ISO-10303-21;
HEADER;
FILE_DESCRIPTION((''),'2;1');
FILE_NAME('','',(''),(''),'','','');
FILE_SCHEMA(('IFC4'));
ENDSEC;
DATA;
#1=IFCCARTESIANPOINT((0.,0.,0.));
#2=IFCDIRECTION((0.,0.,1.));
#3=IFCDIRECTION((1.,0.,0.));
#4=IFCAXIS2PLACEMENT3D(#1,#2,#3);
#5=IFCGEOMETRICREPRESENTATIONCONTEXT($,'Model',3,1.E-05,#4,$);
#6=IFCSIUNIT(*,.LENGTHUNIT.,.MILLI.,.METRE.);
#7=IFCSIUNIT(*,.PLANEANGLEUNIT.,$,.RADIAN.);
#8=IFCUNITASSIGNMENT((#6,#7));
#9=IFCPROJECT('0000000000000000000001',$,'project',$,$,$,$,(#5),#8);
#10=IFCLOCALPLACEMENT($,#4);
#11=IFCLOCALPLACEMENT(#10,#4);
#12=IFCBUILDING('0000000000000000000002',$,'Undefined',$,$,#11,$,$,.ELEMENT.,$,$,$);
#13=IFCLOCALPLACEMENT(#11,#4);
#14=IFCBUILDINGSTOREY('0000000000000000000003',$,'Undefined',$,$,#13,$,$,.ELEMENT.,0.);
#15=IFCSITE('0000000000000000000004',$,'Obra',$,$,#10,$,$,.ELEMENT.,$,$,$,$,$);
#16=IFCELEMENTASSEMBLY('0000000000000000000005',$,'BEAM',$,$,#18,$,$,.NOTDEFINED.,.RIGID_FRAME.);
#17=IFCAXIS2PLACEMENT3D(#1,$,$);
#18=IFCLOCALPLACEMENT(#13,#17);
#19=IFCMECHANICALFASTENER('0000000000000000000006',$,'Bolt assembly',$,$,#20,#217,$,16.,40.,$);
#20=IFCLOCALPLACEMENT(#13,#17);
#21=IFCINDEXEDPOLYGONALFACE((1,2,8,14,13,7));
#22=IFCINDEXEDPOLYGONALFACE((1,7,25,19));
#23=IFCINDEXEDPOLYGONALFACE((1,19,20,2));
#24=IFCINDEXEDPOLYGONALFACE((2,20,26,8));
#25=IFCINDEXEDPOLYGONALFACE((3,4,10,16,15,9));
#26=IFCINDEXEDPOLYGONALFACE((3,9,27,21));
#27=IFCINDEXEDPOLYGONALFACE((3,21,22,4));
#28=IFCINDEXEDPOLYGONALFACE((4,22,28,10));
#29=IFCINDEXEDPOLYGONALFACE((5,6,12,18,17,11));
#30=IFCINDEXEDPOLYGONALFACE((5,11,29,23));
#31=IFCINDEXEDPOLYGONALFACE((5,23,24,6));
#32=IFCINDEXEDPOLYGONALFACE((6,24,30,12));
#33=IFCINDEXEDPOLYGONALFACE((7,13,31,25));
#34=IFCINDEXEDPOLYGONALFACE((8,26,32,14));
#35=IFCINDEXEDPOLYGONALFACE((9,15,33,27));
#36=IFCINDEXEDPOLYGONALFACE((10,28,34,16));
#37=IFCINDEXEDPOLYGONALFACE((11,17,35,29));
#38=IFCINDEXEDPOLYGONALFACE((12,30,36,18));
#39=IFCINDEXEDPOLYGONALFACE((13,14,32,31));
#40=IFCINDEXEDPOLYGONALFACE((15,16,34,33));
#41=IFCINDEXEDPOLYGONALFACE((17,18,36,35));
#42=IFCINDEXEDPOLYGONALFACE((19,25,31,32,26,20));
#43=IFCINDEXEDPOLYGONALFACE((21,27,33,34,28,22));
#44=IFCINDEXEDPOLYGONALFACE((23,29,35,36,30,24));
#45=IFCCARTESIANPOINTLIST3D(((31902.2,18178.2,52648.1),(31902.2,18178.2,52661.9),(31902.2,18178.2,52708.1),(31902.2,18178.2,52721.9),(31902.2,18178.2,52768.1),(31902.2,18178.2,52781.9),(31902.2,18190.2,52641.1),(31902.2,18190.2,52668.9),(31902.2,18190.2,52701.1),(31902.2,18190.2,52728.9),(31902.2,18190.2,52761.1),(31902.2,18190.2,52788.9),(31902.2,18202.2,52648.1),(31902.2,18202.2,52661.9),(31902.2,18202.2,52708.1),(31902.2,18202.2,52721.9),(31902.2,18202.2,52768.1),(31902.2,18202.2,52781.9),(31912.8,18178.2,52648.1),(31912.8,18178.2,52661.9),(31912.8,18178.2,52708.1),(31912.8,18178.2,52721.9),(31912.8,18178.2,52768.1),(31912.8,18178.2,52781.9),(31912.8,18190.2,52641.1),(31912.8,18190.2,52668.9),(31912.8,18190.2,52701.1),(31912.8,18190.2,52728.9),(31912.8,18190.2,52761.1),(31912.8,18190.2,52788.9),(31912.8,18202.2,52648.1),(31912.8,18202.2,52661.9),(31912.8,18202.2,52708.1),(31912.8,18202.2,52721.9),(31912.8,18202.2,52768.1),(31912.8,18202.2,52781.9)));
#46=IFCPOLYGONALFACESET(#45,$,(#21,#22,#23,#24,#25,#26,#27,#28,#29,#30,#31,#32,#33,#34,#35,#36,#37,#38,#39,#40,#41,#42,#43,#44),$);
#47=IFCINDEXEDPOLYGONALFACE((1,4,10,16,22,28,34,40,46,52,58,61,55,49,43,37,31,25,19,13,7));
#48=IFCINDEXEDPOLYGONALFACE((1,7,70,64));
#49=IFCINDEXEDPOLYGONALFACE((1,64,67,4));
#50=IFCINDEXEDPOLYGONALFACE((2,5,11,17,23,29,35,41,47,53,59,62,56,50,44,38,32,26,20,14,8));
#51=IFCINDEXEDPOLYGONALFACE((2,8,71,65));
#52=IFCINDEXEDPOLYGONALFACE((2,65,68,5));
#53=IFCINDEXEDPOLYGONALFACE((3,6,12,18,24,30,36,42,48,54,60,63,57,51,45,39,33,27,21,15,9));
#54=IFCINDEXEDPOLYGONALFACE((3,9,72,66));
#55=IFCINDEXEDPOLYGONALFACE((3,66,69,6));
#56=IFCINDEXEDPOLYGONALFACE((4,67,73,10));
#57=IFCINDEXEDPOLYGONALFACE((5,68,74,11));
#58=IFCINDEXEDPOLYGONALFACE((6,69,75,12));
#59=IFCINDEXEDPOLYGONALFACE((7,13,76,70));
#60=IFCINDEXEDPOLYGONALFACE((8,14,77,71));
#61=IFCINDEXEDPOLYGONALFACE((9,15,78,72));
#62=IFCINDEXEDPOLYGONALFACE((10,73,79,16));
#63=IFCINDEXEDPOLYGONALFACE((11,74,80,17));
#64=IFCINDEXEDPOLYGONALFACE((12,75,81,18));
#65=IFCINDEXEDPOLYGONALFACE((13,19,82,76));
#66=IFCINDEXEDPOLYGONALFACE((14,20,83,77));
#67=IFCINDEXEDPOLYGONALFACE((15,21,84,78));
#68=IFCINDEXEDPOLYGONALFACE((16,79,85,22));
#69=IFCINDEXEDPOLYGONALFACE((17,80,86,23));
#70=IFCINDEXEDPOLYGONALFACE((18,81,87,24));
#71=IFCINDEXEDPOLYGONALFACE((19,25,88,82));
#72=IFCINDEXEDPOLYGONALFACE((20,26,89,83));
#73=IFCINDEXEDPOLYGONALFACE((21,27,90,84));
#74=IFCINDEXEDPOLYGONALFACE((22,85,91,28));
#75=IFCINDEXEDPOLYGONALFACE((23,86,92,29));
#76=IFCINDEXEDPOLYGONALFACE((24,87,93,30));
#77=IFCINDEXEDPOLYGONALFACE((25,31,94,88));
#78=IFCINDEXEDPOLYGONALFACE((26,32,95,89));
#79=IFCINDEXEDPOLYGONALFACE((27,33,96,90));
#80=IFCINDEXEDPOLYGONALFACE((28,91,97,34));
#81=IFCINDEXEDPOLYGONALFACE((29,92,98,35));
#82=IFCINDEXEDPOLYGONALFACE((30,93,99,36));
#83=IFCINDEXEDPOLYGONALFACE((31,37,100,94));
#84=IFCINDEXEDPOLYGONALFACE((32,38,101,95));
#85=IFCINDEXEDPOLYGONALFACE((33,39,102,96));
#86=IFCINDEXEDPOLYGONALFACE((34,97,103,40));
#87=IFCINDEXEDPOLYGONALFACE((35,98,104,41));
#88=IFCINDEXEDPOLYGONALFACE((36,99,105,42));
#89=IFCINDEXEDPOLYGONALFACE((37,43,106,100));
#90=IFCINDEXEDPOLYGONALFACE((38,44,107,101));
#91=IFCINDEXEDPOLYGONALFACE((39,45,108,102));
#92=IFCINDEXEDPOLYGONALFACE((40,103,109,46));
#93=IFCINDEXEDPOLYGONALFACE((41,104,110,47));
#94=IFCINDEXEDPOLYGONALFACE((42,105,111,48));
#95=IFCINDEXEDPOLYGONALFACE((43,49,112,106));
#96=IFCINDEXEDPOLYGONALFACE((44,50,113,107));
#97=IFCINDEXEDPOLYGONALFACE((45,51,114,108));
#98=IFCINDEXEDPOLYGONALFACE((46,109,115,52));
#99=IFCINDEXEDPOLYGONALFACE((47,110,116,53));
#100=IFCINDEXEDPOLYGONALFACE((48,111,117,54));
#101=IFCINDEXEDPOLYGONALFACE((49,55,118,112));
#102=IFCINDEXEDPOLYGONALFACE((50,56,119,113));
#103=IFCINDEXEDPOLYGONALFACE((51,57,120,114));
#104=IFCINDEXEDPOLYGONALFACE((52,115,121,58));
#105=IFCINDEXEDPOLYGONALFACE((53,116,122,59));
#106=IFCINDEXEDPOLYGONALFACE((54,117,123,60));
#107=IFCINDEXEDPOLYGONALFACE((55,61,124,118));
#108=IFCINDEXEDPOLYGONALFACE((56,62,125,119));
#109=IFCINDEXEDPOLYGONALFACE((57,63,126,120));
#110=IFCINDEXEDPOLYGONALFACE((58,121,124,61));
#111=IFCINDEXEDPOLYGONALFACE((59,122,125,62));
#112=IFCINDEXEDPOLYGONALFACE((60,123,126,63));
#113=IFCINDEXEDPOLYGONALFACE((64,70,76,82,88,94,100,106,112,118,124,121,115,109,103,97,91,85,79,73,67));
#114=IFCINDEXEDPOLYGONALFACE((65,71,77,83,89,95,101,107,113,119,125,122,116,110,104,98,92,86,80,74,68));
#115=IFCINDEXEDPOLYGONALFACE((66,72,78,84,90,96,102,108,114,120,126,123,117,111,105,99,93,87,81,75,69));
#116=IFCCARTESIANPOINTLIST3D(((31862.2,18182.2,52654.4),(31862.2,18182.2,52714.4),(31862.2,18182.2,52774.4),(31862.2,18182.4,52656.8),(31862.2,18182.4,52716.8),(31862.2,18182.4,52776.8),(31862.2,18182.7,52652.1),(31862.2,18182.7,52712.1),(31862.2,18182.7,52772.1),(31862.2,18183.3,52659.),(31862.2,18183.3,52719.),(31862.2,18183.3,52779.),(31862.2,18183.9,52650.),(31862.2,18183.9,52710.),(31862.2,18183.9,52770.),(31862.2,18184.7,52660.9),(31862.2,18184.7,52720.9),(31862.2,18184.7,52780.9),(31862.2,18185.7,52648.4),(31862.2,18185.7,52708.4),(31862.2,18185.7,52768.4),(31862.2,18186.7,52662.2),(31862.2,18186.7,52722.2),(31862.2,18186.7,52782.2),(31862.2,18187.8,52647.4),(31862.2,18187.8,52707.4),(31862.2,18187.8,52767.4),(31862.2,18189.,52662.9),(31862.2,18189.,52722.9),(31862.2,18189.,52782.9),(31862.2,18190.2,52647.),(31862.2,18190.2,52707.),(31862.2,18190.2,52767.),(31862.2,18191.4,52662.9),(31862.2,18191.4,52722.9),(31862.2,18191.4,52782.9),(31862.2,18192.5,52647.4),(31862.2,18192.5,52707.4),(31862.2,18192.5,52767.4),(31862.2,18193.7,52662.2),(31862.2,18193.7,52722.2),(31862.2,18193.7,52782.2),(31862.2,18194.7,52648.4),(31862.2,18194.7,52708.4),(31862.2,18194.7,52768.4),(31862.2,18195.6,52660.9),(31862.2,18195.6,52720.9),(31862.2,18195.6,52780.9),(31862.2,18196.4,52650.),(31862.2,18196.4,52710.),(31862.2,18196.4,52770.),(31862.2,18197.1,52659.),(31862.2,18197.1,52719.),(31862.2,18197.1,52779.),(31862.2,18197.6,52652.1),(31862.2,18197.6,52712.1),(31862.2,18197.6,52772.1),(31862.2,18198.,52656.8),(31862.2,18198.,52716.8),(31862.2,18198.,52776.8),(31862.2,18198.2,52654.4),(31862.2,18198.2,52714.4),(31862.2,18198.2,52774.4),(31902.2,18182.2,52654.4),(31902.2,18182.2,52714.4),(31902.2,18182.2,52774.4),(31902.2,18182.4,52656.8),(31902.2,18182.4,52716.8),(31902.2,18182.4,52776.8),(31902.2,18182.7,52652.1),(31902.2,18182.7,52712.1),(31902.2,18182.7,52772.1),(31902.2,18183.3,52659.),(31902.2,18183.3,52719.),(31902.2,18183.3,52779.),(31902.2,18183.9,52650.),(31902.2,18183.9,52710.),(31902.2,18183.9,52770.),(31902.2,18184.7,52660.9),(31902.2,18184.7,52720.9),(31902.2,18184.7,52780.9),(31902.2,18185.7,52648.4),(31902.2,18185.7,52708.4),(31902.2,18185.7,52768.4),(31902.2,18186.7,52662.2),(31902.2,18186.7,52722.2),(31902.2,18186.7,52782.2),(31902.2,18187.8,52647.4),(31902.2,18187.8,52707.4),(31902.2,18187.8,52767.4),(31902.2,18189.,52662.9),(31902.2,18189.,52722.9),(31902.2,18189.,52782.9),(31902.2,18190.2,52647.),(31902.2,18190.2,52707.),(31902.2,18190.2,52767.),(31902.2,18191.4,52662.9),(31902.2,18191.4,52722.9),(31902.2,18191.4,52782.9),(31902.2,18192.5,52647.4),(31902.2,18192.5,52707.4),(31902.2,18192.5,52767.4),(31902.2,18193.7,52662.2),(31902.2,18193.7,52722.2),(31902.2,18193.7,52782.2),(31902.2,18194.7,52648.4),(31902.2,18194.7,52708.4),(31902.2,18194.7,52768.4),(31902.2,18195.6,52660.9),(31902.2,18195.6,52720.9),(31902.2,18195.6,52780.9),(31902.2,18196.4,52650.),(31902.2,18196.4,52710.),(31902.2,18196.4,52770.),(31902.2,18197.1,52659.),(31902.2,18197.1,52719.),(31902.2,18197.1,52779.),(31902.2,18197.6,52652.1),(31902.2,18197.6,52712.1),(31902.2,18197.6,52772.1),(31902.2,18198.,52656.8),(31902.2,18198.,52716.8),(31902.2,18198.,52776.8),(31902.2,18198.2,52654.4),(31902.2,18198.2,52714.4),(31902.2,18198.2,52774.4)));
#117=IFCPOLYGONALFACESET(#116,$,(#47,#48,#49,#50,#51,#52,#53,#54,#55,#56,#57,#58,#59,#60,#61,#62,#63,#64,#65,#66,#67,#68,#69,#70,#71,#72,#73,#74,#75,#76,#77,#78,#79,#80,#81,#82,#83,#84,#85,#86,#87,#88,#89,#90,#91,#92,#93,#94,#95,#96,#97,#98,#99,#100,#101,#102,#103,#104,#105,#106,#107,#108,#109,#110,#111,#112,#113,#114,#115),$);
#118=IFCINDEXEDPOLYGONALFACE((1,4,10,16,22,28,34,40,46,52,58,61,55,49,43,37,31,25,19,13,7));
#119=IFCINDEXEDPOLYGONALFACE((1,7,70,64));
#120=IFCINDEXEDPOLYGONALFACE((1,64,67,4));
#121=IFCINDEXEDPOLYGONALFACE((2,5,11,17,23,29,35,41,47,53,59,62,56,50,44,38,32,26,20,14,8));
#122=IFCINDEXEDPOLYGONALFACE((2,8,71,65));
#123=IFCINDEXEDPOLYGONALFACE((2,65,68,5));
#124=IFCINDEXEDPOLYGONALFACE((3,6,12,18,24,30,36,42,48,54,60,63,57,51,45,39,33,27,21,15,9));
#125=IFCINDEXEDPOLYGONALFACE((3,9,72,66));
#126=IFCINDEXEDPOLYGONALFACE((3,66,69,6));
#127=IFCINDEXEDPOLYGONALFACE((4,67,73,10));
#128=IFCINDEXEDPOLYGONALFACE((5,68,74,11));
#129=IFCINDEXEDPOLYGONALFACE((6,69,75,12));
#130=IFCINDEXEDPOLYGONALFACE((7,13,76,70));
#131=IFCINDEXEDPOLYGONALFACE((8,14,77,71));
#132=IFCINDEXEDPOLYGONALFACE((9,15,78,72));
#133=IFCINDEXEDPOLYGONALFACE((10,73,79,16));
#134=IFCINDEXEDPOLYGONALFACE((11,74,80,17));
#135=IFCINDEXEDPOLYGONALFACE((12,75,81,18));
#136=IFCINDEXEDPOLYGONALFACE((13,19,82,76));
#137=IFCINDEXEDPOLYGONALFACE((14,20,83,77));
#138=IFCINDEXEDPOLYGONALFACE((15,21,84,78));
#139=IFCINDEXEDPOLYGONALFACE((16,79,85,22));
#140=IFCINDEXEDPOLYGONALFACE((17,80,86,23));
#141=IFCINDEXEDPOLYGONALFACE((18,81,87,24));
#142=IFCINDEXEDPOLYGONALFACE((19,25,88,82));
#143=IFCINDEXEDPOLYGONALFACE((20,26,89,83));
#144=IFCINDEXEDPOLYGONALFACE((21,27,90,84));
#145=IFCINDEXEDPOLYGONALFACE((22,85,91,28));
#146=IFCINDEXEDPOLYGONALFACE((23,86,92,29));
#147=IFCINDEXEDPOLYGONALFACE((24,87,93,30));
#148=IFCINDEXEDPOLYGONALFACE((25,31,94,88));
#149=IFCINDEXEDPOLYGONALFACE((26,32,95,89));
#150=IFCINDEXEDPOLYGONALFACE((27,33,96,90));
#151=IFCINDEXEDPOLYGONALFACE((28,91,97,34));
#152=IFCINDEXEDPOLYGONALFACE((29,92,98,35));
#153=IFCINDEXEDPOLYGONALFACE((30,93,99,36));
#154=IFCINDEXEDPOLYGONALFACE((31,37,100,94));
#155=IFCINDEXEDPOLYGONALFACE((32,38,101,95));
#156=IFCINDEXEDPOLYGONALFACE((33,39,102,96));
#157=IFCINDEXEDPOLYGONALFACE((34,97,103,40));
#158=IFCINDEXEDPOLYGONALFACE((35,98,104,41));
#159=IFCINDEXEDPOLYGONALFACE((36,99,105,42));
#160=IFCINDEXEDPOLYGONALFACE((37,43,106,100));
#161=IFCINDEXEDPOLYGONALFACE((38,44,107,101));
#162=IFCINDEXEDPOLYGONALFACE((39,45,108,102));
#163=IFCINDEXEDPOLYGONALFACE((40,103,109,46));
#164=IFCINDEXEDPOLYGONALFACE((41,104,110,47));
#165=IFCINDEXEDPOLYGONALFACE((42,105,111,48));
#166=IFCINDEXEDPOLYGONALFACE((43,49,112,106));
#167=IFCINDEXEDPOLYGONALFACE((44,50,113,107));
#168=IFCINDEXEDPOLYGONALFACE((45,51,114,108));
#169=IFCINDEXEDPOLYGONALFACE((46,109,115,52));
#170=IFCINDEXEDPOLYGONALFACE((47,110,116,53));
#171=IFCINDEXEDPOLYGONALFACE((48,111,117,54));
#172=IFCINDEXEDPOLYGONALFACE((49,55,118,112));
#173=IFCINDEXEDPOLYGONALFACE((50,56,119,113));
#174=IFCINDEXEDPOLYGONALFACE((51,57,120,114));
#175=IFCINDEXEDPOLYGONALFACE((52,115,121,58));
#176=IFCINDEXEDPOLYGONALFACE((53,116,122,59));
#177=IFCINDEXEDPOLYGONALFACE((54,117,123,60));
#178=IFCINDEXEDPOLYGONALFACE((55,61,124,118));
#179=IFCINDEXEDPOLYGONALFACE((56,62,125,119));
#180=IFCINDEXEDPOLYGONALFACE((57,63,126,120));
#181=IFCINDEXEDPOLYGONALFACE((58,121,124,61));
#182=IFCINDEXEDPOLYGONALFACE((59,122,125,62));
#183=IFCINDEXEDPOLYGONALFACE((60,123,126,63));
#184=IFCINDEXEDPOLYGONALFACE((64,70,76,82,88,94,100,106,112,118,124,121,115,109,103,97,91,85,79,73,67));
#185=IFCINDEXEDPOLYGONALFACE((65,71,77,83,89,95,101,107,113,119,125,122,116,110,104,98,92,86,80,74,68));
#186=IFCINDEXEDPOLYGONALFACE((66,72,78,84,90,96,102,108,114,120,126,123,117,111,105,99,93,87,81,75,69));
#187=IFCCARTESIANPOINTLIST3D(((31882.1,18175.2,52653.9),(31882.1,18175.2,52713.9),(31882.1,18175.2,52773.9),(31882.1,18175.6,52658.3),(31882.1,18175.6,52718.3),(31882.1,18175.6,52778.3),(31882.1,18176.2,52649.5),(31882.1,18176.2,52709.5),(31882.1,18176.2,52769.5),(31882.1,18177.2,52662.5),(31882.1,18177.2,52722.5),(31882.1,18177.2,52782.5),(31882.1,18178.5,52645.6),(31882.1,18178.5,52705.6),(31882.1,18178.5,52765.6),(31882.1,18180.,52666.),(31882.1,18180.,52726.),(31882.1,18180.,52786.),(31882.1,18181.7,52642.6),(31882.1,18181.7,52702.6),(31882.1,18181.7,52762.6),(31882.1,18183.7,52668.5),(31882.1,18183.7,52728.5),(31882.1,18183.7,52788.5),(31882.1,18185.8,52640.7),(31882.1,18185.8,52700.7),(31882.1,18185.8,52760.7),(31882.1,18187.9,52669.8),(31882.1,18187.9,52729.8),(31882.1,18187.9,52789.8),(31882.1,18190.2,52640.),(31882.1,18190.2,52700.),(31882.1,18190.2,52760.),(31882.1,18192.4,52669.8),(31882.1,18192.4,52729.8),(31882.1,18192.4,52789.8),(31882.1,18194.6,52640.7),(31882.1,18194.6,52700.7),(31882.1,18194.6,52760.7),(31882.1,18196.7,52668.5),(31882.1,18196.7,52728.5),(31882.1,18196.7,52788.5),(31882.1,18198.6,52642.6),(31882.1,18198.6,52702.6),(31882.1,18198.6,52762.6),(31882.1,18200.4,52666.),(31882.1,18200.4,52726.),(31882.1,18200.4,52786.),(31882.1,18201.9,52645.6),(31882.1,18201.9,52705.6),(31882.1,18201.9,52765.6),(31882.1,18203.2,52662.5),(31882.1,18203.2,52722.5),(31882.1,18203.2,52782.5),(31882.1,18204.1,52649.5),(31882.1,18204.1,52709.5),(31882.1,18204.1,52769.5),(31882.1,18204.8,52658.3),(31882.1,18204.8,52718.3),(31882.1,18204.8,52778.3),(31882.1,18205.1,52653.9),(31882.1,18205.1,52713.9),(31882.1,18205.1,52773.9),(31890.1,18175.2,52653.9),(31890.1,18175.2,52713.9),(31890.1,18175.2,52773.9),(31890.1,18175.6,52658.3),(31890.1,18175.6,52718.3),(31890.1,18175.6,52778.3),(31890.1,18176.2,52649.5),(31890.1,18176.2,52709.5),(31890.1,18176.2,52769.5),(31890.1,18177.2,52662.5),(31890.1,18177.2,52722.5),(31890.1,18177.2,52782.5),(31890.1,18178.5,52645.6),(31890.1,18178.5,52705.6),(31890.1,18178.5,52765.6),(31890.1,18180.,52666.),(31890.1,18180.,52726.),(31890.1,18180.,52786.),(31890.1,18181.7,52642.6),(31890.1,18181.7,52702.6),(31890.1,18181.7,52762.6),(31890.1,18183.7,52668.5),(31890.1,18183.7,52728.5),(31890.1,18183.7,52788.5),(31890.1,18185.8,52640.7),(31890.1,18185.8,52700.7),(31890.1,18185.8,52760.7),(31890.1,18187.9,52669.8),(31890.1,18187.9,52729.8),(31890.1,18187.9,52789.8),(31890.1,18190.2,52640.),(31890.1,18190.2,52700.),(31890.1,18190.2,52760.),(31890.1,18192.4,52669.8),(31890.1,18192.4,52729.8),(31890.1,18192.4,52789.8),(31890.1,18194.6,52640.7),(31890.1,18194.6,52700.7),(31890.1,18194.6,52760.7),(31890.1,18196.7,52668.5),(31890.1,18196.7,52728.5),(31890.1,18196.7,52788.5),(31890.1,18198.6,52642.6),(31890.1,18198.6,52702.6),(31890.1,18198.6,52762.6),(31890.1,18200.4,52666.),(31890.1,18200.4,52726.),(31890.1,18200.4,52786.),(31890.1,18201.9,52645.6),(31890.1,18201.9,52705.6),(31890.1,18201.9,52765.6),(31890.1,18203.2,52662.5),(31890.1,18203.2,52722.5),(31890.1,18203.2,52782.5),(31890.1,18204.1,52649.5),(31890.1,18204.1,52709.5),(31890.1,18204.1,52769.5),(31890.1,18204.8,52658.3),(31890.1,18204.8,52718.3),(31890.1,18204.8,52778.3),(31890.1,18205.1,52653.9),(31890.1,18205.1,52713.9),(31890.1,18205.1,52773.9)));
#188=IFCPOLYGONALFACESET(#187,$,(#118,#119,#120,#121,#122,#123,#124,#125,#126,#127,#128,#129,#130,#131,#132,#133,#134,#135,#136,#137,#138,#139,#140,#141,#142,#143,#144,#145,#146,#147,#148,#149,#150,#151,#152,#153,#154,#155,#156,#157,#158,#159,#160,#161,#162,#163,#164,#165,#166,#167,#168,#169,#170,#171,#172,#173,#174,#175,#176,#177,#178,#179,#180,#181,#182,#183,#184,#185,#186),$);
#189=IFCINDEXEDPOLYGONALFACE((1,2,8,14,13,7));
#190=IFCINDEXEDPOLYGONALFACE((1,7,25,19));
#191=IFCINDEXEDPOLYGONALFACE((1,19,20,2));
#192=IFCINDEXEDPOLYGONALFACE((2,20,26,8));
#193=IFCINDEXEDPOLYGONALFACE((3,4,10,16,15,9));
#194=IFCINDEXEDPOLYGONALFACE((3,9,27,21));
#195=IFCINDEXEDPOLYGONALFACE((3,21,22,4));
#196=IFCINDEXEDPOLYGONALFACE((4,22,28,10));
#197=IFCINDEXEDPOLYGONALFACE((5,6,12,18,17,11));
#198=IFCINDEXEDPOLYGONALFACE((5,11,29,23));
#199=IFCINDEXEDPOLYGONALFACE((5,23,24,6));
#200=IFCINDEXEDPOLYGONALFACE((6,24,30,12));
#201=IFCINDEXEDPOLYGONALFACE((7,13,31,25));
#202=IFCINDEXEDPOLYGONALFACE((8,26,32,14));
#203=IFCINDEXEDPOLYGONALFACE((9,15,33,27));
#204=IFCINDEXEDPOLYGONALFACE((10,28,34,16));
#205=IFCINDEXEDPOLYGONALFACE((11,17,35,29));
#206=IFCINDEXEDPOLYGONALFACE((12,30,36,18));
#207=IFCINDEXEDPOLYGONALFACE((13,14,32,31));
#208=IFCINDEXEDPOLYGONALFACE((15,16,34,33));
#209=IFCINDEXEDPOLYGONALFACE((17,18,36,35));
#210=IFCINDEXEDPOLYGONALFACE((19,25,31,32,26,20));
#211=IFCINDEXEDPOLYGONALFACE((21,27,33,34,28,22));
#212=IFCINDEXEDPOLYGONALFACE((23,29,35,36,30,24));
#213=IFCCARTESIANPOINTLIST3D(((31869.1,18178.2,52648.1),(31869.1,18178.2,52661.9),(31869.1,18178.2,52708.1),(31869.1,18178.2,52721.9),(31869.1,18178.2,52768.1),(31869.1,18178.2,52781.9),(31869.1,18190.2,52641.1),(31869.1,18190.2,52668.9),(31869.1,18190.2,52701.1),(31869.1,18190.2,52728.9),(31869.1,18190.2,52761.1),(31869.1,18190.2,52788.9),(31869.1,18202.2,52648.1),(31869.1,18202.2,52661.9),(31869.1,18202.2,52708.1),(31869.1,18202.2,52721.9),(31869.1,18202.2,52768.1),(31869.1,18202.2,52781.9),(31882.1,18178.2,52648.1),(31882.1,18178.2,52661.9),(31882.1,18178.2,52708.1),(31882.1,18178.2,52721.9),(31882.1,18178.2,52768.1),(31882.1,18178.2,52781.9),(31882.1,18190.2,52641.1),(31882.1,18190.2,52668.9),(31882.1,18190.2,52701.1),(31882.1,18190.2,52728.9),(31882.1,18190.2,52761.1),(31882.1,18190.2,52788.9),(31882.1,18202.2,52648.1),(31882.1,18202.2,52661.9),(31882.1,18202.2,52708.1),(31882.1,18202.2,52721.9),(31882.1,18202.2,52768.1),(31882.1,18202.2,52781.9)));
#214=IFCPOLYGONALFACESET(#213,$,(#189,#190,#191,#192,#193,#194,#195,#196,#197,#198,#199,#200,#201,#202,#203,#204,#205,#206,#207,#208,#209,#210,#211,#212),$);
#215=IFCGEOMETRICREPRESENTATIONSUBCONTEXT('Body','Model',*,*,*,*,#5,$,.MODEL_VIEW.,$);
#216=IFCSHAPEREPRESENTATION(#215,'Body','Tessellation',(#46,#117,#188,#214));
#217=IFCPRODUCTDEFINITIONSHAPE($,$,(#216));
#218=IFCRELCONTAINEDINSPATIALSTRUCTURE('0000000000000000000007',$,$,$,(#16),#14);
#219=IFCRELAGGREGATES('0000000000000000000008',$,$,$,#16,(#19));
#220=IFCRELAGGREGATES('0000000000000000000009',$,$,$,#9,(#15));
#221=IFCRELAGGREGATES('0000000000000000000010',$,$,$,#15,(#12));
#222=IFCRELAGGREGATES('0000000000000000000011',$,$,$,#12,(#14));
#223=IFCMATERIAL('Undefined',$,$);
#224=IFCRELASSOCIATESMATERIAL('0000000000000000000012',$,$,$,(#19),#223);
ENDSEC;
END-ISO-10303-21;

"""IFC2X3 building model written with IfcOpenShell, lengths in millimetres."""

from ifc_helpers import new_model, si_unit, frame, origin_with_axes, origin_2d_with_axis, place, context, subcontext, project, spatial, polyline, circle, outline, extrude, source, transform, mapped, material, element, aggregate, save


model = new_model("IFC2X3")

# Units and contexts
model_context = context("Model", 3, precision=1e-05, world=origin_with_axes())
body_context = subcontext(model_context, "Body", "Model", "MODEL_VIEW")
ifc_project = project(units=[si_unit("LENGTHUNIT", "METRE", prefix="MILLI"), si_unit("PLANEANGLEUNIT", "RADIAN")], contexts=[model_context])

# Site, building, storey
site_placement = place(None, origin_with_axes())
site = spatial("IfcSite", under=ifc_project, at=site_placement, Name="Obra", CompositionType="ELEMENT")
building_placement = place(site_placement, origin_with_axes())
building = spatial("IfcBuilding", under=site, at=building_placement, Name="Undefined", CompositionType="ELEMENT")
storey_placement = place(building_placement, origin_with_axes())
storey = spatial("IfcBuildingStorey", under=building, at=storey_placement, Name="Undefined", CompositionType="ELEMENT", Elevation=0.0)

# Element assembly
assembly_1_placement = place(storey_placement, origin_with_axes())
assembly_1 = element("IfcElementAssembly", 1, at=assembly_1_placement, inside=storey, Name="BEAM", AssemblyPlace="NOTDEFINED", PredefinedType="RIGID_FRAME")

# Mechanical fastener
ifc_material_1 = material(Name="Undefined")
shared_shape_1 = source(origin_with_axes(), body_context, "Body", "SweptSolid", [
    extrude(outline(polyline([(13.9, 0.0), (6.9, 12.0), (-6.9, 12.0), (-13.9, 0.0), (-6.9, -12.0), (6.9, -12.0), (13.9, 0.0)])), frame((0.0, -19.7, 0.0), z_axis=(0.0, 1.0, 0.0), x_axis=(1.0, 0.0, 0.0)), (0.0, 0.0, 1.0), 10.6),
    extrude(circle(Radius=8.0, at=origin_2d_with_axis()), frame((0.0, -9.1, 0.0), z_axis=(0.0, 1.0, 0.0), x_axis=(1.0, 0.0, 0.0)), (0.0, 0.0, 1.0), 40.0),
    extrude(circle(Radius=15.0, at=origin_2d_with_axis()), frame((0.0, 3.0, 0.0), z_axis=(0.0, 1.0, 0.0), x_axis=(1.0, 0.0, 0.0)), (0.0, 0.0, 1.0), 8.0),
    extrude(outline(polyline([(13.9, 0.0), (6.9, 12.0), (-6.9, 12.0), (-13.9, 0.0), (-6.9, -12.0), (6.9, -12.0), (13.9, 0.0)])), frame((0.0, 11.0, 0.0), z_axis=(0.0, 1.0, 0.0), x_axis=(1.0, 0.0, 0.0)), (0.0, 0.0, 1.0), 13.0),
])
mechanical_fastener_1_placement = place(assembly_1_placement, frame((31893.1, 18140.2, 52835.0), z_axis=(-0.000002, 1.0, 0.0), x_axis=(0.0, 0.0, -1.0)))
mechanical_fastener_1 = element("IfcMechanicalFastener", 2, at=mechanical_fastener_1_placement, material=ifc_material_1, Name="Bolt assembly", NominalDiameter=16.0, NominalLength=40.0, context=body_context, shape_type="MappedRepresentation", body=[
    mapped(shared_shape_1, transform((60.0, 0.0, 50.0))),
    mapped(shared_shape_1, transform((120.0, 0.0, 50.0))),
    mapped(shared_shape_1, transform((180.0, 0.0, 50.0))),
])
aggregate(assembly_1, [mechanical_fastener_1])

save(model, "model.ifc")
